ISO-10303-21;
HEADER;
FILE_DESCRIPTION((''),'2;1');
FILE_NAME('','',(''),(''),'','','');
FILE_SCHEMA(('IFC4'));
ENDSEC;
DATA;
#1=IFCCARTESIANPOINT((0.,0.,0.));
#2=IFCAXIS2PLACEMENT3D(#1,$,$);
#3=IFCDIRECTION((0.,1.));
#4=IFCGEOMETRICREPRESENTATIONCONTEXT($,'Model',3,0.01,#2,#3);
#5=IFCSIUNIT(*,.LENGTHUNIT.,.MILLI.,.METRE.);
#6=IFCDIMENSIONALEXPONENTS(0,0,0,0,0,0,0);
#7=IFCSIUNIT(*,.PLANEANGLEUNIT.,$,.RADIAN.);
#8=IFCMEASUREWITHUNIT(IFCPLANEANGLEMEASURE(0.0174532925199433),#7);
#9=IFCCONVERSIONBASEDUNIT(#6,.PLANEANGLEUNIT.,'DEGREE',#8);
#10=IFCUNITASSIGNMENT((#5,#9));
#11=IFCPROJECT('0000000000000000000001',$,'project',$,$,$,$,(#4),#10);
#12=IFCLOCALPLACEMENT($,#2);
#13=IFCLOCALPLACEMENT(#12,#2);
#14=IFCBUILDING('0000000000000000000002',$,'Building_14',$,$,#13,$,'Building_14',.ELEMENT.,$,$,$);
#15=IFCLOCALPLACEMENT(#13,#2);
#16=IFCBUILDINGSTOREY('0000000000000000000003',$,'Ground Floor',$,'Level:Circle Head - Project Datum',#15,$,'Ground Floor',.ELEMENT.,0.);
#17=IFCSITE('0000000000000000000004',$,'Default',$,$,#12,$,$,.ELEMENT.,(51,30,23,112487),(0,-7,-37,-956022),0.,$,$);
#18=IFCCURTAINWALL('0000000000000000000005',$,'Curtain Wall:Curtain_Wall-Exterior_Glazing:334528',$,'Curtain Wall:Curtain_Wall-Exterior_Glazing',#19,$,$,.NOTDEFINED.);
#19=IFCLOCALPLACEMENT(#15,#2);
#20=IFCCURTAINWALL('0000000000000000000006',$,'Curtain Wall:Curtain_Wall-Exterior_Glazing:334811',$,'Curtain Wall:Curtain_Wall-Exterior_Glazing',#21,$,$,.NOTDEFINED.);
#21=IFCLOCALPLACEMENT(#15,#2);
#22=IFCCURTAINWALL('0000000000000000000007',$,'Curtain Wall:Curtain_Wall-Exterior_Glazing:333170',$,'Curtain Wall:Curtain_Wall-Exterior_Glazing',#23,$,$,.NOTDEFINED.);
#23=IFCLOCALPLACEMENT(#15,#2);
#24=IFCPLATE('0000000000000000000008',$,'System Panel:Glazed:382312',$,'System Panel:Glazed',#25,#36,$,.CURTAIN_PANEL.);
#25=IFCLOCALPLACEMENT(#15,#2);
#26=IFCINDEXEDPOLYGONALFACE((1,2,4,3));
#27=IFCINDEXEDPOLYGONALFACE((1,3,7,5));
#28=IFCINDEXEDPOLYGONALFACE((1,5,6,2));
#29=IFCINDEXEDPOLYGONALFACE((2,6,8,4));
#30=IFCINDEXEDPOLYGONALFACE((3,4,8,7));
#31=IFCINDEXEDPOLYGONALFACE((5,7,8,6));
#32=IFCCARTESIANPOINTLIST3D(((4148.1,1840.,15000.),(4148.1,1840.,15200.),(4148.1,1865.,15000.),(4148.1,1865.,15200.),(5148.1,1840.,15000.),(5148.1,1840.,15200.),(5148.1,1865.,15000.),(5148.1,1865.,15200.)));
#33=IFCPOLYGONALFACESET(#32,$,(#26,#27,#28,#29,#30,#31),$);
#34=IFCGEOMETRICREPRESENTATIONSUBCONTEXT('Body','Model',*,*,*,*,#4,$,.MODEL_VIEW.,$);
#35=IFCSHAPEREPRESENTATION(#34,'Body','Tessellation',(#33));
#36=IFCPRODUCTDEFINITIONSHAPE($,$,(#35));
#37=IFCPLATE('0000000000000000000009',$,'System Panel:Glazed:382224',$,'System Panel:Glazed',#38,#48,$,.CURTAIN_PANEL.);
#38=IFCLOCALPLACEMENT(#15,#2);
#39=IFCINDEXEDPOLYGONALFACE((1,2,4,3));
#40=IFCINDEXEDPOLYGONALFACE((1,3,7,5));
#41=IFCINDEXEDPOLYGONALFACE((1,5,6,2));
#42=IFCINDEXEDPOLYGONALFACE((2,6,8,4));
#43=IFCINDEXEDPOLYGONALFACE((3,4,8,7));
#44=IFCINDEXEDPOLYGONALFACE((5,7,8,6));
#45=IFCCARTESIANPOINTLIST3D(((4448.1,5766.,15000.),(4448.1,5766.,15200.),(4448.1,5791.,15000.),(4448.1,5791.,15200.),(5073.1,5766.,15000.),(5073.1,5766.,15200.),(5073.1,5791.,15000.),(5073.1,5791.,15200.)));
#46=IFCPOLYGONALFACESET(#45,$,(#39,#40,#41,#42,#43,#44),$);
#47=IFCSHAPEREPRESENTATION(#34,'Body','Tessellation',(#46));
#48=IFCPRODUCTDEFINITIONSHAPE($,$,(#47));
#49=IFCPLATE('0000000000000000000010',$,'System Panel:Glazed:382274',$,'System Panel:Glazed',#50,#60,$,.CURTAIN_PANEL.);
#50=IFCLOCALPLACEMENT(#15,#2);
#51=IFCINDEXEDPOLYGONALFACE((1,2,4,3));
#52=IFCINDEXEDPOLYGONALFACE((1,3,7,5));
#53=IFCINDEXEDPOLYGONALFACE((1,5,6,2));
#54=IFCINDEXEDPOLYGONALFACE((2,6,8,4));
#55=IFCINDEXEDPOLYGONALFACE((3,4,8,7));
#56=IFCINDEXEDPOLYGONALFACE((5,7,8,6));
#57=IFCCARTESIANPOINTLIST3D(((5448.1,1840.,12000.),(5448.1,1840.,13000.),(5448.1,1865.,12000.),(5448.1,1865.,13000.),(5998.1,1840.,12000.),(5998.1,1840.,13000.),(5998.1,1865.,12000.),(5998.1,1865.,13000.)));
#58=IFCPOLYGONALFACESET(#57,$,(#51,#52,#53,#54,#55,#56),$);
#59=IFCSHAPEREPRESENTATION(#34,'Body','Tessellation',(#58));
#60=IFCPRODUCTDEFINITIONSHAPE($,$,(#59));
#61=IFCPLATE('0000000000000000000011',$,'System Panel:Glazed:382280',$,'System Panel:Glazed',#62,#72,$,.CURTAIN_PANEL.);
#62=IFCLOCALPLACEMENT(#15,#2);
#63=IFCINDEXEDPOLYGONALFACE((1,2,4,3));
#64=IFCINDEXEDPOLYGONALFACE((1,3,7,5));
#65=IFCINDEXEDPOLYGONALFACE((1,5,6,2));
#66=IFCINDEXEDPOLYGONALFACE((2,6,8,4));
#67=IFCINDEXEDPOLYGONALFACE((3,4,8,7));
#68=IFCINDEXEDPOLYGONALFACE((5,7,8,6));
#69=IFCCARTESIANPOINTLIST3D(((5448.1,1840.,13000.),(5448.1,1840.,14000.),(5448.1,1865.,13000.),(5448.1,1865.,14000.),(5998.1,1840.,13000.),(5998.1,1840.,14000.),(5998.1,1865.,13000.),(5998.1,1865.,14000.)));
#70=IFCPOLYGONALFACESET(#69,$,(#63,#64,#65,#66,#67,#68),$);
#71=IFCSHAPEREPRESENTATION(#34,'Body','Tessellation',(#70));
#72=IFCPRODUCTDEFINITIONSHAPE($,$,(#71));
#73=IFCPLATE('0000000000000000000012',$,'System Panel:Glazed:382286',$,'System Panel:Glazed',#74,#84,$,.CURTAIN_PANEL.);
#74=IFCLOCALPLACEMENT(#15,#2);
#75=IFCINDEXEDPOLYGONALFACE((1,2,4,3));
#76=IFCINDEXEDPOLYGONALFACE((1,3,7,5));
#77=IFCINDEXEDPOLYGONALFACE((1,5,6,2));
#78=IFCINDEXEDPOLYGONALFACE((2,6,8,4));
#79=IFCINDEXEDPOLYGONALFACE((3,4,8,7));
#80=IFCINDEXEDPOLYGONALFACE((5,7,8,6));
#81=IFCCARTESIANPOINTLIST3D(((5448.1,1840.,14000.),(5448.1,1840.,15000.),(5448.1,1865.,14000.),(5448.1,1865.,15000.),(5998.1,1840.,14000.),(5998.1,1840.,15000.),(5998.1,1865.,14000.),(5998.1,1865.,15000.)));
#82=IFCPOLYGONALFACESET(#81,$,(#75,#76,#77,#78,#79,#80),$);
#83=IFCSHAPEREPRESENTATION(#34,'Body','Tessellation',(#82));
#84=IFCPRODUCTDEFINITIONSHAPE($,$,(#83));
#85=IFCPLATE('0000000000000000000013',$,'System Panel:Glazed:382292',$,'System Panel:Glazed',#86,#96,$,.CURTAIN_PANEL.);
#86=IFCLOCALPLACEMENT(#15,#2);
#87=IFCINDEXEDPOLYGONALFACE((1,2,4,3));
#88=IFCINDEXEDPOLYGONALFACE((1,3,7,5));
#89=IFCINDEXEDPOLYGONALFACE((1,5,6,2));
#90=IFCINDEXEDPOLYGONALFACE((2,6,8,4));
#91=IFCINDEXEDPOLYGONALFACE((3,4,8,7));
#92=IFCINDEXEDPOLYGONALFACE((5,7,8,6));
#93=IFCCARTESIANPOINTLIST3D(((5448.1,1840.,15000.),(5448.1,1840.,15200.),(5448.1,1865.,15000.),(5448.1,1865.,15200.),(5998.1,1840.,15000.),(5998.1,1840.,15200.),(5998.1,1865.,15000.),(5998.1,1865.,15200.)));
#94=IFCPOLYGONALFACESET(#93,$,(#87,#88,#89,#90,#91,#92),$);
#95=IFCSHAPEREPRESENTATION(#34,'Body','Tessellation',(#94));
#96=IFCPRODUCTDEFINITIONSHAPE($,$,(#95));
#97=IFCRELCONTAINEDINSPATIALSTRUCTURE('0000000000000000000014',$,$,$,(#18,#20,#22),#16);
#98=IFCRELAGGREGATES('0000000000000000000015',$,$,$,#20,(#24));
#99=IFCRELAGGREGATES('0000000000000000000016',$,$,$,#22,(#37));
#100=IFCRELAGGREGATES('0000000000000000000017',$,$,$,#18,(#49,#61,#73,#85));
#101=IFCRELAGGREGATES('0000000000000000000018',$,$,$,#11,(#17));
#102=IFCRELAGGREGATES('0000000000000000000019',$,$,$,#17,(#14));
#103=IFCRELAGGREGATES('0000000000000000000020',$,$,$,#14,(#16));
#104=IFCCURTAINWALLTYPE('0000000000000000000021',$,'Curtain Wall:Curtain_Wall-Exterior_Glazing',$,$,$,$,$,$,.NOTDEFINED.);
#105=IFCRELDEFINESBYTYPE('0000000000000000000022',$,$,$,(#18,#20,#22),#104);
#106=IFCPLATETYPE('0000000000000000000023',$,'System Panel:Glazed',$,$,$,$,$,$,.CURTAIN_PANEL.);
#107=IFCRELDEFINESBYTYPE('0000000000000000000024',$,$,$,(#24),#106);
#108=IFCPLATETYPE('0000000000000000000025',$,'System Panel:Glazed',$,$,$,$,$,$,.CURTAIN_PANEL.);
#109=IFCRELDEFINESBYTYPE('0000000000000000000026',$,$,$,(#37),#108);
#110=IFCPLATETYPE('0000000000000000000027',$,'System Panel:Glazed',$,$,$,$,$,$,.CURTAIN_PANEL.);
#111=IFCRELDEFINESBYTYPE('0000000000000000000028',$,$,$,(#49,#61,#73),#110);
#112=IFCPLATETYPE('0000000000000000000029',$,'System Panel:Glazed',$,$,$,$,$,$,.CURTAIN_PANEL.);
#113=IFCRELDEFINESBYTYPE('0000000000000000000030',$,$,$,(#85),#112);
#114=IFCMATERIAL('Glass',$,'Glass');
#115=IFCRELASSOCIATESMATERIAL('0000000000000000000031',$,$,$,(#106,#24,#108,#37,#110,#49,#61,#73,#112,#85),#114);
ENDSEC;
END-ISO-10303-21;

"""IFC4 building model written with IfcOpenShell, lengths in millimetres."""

from ifc_helpers import new_model, entity, si_unit, converted_unit, direction, frame, origin, place, context, subcontext, project, spatial, indexed_curve, outline, extrude, source, transform, mapped, material, type_object, type_shapes, element, aggregate, save


model = new_model("IFC4")

# Units and contexts
model_context = context("Model", 3, precision=0.01, world=origin(), true_north=direction((0.0, 1.0)))
body_context = subcontext(model_context, "Body", "Model", "MODEL_VIEW")
ifc_project = project(units=[si_unit("LENGTHUNIT", "METRE", prefix="MILLI"), converted_unit("PLANEANGLEUNIT", "DEGREE", entity("IfcPlaneAngleMeasure", 0.0174532925199433), si_unit("PLANEANGLEUNIT", "RADIAN"), dimensions=[0, 0, 0, 0, 0, 0, 0])], contexts=[model_context])

# Site, building, storey
site_placement = place(None, origin())
site = spatial("IfcSite", under=ifc_project, at=site_placement, Name="Default", CompositionType="ELEMENT", RefLatitude=(51, 30, 23, 112487), RefLongitude=(0, -7, -37, -956022), RefElevation=0.0)
building_placement = place(site_placement, origin())
building = spatial("IfcBuilding", under=site, at=building_placement, Name="Building_14", LongName="Building_14", CompositionType="ELEMENT")
storey_placement = place(building_placement, origin())
storey = spatial("IfcBuildingStorey", under=building, at=storey_placement, Name="Ground Floor", ObjectType="Level:Circle Head - Project Datum", LongName="Ground Floor", CompositionType="ELEMENT", Elevation=0.0)

# Curtain walls
curtain_wall_type = type_object("IfcCurtainWallType", Name="Curtain Wall:Curtain_Wall-Exterior_Glazing", PredefinedType="NOTDEFINED")
ifc_material = material(Name="Glass", Category="Glass")
curtain_wall_1_placement = place(storey_placement, origin())
curtain_wall_1 = element("IfcCurtainWall", 1, at=curtain_wall_1_placement, inside=storey, type_object=curtain_wall_type, Name="Curtain Wall:Curtain_Wall-Exterior_Glazing:334528", ObjectType="Curtain Wall:Curtain_Wall-Exterior_Glazing", PredefinedType="NOTDEFINED")
curtain_wall_2_placement = place(storey_placement, origin())
curtain_wall_2 = element("IfcCurtainWall", 2, at=curtain_wall_2_placement, inside=storey, type_object=curtain_wall_type, Name="Curtain Wall:Curtain_Wall-Exterior_Glazing:334811", ObjectType="Curtain Wall:Curtain_Wall-Exterior_Glazing", PredefinedType="NOTDEFINED")
curtain_wall_3_placement = place(storey_placement, origin())
curtain_wall_3 = element("IfcCurtainWall", 3, at=curtain_wall_3_placement, inside=storey, type_object=curtain_wall_type, Name="Curtain Wall:Curtain_Wall-Exterior_Glazing:333170", ObjectType="Curtain Wall:Curtain_Wall-Exterior_Glazing", PredefinedType="NOTDEFINED")
plate_type_1 = type_object("IfcPlateType", Name="System Panel:Glazed", PredefinedType="CURTAIN_PANEL", material=ifc_material)
shared_shape_1 = source(origin(), body_context, "Body", "SweptSolid", [
    extrude(outline(indexed_curve([(-12.5, -500.0), (12.5, -500.0), (12.5, 500.0), (-12.5, 500.0), (-12.5, -500.0)], self_intersect=False)), frame((0.0, -37.0, 0.0), z_axis=(0.0, 0.0, 1.0), x_axis=(0.0, 1.0, 0.0)), (0.0, 0.0, 1.0), 200.0),
])
type_shapes(plate_type_1, [shared_shape_1])

# Plates
plate_1_placement = place(curtain_wall_2_placement, frame((4648.1, 1815.5, 15000.0), z_axis=(0.0, 0.0, 1.0), x_axis=(-1.0, 0.0, 0.0)))
plate_1 = element("IfcPlate", 4, at=plate_1_placement, type_object=plate_type_1, material=ifc_material, Name="System Panel:Glazed:382312", ObjectType="System Panel:Glazed", PredefinedType="CURTAIN_PANEL", context=body_context, shape_type="MappedRepresentation", body=[
    mapped(shared_shape_1, transform((0.0, 0.0, 0.0), scale=1.0)),
])
aggregate(curtain_wall_2, [plate_1])
plate_type_2 = type_object("IfcPlateType", Name="System Panel:Glazed", PredefinedType="CURTAIN_PANEL", material=ifc_material)
shared_shape_2 = source(origin(), body_context, "Body", "SweptSolid", [
    extrude(outline(indexed_curve([(-12.5, -312.5), (12.5, -312.5), (12.5, 312.5), (-12.5, 312.5), (-12.5, -312.5)], self_intersect=False)), frame((0.0, -37.0, 0.0), z_axis=(0.0, 0.0, 1.0), x_axis=(0.0, 1.0, 0.0)), (0.0, 0.0, 1.0), 200.0),
])
type_shapes(plate_type_2, [shared_shape_2])
plate_2_placement = place(curtain_wall_3_placement, frame((4760.6, 5815.5, 15000.0)))
plate_2 = element("IfcPlate", 5, at=plate_2_placement, type_object=plate_type_2, material=ifc_material, Name="System Panel:Glazed:382224", ObjectType="System Panel:Glazed", PredefinedType="CURTAIN_PANEL", context=body_context, shape_type="MappedRepresentation", body=[
    mapped(shared_shape_2, transform((0.0, 0.0, 0.0), scale=1.0)),
])
aggregate(curtain_wall_3, [plate_2])
plate_type_3 = type_object("IfcPlateType", Name="System Panel:Glazed", PredefinedType="CURTAIN_PANEL", material=ifc_material)
shared_shape_3 = source(origin(), body_context, "Body", "SweptSolid", [
    extrude(outline(indexed_curve([(-12.5, -275.0), (12.5, -275.0), (12.5, 275.0), (-12.5, 275.0), (-12.5, -275.0)], self_intersect=False)), frame((0.0, -37.0, 0.0), z_axis=(0.0, 0.0, 1.0), x_axis=(0.0, 1.0, 0.0)), (0.0, 0.0, 1.0), 1000.0),
])
type_shapes(plate_type_3, [shared_shape_3])
plate_3_placement = place(curtain_wall_1_placement, frame((5723.1, 1815.5, 12000.0), z_axis=(0.0, 0.0, 1.0), x_axis=(-1.0, 0.0, 0.0)))
plate_3 = element("IfcPlate", 6, at=plate_3_placement, type_object=plate_type_3, material=ifc_material, Name="System Panel:Glazed:382274", ObjectType="System Panel:Glazed", PredefinedType="CURTAIN_PANEL", context=body_context, shape_type="MappedRepresentation", body=[
    mapped(shared_shape_3, transform((0.0, 0.0, 0.0), scale=1.0)),
])
plate_4_placement = place(curtain_wall_1_placement, frame((5723.1, 1815.5, 13000.0), z_axis=(0.0, 0.0, 1.0), x_axis=(-1.0, 0.0, 0.0)))
plate_4 = element("IfcPlate", 7, at=plate_4_placement, type_object=plate_type_3, material=ifc_material, Name="System Panel:Glazed:382280", ObjectType="System Panel:Glazed", PredefinedType="CURTAIN_PANEL", context=body_context, shape_type="MappedRepresentation", body=[
    mapped(shared_shape_3, transform((0.0, 0.0, 0.0), scale=1.0)),
])
plate_5_placement = place(curtain_wall_1_placement, frame((5723.1, 1815.5, 14000.0), z_axis=(0.0, 0.0, 1.0), x_axis=(-1.0, 0.0, 0.0)))
plate_5 = element("IfcPlate", 8, at=plate_5_placement, type_object=plate_type_3, material=ifc_material, Name="System Panel:Glazed:382286", ObjectType="System Panel:Glazed", PredefinedType="CURTAIN_PANEL", context=body_context, shape_type="MappedRepresentation", body=[
    mapped(shared_shape_3, transform((0.0, 0.0, 0.0), scale=1.0)),
])
plate_type_4 = type_object("IfcPlateType", Name="System Panel:Glazed", PredefinedType="CURTAIN_PANEL", material=ifc_material)
shared_shape_4 = source(origin(), body_context, "Body", "SweptSolid", [
    extrude(outline(indexed_curve([(-12.5, -275.0), (12.5, -275.0), (12.5, 275.0), (-12.5, 275.0), (-12.5, -275.0)], self_intersect=False)), frame((0.0, -37.0, 0.0), z_axis=(0.0, 0.0, 1.0), x_axis=(0.0, 1.0, 0.0)), (0.0, 0.0, 1.0), 200.0),
])
type_shapes(plate_type_4, [shared_shape_4])
plate_6_placement = place(curtain_wall_1_placement, frame((5723.1, 1815.5, 15000.0), z_axis=(0.0, 0.0, 1.0), x_axis=(-1.0, 0.0, 0.0)))
plate_6 = element("IfcPlate", 9, at=plate_6_placement, type_object=plate_type_4, material=ifc_material, Name="System Panel:Glazed:382292", ObjectType="System Panel:Glazed", PredefinedType="CURTAIN_PANEL", context=body_context, shape_type="MappedRepresentation", body=[
    mapped(shared_shape_4, transform((0.0, 0.0, 0.0), scale=1.0)),
])
aggregate(curtain_wall_1, [plate_3, plate_4, plate_5, plate_6])

save(model, "model.ifc")
